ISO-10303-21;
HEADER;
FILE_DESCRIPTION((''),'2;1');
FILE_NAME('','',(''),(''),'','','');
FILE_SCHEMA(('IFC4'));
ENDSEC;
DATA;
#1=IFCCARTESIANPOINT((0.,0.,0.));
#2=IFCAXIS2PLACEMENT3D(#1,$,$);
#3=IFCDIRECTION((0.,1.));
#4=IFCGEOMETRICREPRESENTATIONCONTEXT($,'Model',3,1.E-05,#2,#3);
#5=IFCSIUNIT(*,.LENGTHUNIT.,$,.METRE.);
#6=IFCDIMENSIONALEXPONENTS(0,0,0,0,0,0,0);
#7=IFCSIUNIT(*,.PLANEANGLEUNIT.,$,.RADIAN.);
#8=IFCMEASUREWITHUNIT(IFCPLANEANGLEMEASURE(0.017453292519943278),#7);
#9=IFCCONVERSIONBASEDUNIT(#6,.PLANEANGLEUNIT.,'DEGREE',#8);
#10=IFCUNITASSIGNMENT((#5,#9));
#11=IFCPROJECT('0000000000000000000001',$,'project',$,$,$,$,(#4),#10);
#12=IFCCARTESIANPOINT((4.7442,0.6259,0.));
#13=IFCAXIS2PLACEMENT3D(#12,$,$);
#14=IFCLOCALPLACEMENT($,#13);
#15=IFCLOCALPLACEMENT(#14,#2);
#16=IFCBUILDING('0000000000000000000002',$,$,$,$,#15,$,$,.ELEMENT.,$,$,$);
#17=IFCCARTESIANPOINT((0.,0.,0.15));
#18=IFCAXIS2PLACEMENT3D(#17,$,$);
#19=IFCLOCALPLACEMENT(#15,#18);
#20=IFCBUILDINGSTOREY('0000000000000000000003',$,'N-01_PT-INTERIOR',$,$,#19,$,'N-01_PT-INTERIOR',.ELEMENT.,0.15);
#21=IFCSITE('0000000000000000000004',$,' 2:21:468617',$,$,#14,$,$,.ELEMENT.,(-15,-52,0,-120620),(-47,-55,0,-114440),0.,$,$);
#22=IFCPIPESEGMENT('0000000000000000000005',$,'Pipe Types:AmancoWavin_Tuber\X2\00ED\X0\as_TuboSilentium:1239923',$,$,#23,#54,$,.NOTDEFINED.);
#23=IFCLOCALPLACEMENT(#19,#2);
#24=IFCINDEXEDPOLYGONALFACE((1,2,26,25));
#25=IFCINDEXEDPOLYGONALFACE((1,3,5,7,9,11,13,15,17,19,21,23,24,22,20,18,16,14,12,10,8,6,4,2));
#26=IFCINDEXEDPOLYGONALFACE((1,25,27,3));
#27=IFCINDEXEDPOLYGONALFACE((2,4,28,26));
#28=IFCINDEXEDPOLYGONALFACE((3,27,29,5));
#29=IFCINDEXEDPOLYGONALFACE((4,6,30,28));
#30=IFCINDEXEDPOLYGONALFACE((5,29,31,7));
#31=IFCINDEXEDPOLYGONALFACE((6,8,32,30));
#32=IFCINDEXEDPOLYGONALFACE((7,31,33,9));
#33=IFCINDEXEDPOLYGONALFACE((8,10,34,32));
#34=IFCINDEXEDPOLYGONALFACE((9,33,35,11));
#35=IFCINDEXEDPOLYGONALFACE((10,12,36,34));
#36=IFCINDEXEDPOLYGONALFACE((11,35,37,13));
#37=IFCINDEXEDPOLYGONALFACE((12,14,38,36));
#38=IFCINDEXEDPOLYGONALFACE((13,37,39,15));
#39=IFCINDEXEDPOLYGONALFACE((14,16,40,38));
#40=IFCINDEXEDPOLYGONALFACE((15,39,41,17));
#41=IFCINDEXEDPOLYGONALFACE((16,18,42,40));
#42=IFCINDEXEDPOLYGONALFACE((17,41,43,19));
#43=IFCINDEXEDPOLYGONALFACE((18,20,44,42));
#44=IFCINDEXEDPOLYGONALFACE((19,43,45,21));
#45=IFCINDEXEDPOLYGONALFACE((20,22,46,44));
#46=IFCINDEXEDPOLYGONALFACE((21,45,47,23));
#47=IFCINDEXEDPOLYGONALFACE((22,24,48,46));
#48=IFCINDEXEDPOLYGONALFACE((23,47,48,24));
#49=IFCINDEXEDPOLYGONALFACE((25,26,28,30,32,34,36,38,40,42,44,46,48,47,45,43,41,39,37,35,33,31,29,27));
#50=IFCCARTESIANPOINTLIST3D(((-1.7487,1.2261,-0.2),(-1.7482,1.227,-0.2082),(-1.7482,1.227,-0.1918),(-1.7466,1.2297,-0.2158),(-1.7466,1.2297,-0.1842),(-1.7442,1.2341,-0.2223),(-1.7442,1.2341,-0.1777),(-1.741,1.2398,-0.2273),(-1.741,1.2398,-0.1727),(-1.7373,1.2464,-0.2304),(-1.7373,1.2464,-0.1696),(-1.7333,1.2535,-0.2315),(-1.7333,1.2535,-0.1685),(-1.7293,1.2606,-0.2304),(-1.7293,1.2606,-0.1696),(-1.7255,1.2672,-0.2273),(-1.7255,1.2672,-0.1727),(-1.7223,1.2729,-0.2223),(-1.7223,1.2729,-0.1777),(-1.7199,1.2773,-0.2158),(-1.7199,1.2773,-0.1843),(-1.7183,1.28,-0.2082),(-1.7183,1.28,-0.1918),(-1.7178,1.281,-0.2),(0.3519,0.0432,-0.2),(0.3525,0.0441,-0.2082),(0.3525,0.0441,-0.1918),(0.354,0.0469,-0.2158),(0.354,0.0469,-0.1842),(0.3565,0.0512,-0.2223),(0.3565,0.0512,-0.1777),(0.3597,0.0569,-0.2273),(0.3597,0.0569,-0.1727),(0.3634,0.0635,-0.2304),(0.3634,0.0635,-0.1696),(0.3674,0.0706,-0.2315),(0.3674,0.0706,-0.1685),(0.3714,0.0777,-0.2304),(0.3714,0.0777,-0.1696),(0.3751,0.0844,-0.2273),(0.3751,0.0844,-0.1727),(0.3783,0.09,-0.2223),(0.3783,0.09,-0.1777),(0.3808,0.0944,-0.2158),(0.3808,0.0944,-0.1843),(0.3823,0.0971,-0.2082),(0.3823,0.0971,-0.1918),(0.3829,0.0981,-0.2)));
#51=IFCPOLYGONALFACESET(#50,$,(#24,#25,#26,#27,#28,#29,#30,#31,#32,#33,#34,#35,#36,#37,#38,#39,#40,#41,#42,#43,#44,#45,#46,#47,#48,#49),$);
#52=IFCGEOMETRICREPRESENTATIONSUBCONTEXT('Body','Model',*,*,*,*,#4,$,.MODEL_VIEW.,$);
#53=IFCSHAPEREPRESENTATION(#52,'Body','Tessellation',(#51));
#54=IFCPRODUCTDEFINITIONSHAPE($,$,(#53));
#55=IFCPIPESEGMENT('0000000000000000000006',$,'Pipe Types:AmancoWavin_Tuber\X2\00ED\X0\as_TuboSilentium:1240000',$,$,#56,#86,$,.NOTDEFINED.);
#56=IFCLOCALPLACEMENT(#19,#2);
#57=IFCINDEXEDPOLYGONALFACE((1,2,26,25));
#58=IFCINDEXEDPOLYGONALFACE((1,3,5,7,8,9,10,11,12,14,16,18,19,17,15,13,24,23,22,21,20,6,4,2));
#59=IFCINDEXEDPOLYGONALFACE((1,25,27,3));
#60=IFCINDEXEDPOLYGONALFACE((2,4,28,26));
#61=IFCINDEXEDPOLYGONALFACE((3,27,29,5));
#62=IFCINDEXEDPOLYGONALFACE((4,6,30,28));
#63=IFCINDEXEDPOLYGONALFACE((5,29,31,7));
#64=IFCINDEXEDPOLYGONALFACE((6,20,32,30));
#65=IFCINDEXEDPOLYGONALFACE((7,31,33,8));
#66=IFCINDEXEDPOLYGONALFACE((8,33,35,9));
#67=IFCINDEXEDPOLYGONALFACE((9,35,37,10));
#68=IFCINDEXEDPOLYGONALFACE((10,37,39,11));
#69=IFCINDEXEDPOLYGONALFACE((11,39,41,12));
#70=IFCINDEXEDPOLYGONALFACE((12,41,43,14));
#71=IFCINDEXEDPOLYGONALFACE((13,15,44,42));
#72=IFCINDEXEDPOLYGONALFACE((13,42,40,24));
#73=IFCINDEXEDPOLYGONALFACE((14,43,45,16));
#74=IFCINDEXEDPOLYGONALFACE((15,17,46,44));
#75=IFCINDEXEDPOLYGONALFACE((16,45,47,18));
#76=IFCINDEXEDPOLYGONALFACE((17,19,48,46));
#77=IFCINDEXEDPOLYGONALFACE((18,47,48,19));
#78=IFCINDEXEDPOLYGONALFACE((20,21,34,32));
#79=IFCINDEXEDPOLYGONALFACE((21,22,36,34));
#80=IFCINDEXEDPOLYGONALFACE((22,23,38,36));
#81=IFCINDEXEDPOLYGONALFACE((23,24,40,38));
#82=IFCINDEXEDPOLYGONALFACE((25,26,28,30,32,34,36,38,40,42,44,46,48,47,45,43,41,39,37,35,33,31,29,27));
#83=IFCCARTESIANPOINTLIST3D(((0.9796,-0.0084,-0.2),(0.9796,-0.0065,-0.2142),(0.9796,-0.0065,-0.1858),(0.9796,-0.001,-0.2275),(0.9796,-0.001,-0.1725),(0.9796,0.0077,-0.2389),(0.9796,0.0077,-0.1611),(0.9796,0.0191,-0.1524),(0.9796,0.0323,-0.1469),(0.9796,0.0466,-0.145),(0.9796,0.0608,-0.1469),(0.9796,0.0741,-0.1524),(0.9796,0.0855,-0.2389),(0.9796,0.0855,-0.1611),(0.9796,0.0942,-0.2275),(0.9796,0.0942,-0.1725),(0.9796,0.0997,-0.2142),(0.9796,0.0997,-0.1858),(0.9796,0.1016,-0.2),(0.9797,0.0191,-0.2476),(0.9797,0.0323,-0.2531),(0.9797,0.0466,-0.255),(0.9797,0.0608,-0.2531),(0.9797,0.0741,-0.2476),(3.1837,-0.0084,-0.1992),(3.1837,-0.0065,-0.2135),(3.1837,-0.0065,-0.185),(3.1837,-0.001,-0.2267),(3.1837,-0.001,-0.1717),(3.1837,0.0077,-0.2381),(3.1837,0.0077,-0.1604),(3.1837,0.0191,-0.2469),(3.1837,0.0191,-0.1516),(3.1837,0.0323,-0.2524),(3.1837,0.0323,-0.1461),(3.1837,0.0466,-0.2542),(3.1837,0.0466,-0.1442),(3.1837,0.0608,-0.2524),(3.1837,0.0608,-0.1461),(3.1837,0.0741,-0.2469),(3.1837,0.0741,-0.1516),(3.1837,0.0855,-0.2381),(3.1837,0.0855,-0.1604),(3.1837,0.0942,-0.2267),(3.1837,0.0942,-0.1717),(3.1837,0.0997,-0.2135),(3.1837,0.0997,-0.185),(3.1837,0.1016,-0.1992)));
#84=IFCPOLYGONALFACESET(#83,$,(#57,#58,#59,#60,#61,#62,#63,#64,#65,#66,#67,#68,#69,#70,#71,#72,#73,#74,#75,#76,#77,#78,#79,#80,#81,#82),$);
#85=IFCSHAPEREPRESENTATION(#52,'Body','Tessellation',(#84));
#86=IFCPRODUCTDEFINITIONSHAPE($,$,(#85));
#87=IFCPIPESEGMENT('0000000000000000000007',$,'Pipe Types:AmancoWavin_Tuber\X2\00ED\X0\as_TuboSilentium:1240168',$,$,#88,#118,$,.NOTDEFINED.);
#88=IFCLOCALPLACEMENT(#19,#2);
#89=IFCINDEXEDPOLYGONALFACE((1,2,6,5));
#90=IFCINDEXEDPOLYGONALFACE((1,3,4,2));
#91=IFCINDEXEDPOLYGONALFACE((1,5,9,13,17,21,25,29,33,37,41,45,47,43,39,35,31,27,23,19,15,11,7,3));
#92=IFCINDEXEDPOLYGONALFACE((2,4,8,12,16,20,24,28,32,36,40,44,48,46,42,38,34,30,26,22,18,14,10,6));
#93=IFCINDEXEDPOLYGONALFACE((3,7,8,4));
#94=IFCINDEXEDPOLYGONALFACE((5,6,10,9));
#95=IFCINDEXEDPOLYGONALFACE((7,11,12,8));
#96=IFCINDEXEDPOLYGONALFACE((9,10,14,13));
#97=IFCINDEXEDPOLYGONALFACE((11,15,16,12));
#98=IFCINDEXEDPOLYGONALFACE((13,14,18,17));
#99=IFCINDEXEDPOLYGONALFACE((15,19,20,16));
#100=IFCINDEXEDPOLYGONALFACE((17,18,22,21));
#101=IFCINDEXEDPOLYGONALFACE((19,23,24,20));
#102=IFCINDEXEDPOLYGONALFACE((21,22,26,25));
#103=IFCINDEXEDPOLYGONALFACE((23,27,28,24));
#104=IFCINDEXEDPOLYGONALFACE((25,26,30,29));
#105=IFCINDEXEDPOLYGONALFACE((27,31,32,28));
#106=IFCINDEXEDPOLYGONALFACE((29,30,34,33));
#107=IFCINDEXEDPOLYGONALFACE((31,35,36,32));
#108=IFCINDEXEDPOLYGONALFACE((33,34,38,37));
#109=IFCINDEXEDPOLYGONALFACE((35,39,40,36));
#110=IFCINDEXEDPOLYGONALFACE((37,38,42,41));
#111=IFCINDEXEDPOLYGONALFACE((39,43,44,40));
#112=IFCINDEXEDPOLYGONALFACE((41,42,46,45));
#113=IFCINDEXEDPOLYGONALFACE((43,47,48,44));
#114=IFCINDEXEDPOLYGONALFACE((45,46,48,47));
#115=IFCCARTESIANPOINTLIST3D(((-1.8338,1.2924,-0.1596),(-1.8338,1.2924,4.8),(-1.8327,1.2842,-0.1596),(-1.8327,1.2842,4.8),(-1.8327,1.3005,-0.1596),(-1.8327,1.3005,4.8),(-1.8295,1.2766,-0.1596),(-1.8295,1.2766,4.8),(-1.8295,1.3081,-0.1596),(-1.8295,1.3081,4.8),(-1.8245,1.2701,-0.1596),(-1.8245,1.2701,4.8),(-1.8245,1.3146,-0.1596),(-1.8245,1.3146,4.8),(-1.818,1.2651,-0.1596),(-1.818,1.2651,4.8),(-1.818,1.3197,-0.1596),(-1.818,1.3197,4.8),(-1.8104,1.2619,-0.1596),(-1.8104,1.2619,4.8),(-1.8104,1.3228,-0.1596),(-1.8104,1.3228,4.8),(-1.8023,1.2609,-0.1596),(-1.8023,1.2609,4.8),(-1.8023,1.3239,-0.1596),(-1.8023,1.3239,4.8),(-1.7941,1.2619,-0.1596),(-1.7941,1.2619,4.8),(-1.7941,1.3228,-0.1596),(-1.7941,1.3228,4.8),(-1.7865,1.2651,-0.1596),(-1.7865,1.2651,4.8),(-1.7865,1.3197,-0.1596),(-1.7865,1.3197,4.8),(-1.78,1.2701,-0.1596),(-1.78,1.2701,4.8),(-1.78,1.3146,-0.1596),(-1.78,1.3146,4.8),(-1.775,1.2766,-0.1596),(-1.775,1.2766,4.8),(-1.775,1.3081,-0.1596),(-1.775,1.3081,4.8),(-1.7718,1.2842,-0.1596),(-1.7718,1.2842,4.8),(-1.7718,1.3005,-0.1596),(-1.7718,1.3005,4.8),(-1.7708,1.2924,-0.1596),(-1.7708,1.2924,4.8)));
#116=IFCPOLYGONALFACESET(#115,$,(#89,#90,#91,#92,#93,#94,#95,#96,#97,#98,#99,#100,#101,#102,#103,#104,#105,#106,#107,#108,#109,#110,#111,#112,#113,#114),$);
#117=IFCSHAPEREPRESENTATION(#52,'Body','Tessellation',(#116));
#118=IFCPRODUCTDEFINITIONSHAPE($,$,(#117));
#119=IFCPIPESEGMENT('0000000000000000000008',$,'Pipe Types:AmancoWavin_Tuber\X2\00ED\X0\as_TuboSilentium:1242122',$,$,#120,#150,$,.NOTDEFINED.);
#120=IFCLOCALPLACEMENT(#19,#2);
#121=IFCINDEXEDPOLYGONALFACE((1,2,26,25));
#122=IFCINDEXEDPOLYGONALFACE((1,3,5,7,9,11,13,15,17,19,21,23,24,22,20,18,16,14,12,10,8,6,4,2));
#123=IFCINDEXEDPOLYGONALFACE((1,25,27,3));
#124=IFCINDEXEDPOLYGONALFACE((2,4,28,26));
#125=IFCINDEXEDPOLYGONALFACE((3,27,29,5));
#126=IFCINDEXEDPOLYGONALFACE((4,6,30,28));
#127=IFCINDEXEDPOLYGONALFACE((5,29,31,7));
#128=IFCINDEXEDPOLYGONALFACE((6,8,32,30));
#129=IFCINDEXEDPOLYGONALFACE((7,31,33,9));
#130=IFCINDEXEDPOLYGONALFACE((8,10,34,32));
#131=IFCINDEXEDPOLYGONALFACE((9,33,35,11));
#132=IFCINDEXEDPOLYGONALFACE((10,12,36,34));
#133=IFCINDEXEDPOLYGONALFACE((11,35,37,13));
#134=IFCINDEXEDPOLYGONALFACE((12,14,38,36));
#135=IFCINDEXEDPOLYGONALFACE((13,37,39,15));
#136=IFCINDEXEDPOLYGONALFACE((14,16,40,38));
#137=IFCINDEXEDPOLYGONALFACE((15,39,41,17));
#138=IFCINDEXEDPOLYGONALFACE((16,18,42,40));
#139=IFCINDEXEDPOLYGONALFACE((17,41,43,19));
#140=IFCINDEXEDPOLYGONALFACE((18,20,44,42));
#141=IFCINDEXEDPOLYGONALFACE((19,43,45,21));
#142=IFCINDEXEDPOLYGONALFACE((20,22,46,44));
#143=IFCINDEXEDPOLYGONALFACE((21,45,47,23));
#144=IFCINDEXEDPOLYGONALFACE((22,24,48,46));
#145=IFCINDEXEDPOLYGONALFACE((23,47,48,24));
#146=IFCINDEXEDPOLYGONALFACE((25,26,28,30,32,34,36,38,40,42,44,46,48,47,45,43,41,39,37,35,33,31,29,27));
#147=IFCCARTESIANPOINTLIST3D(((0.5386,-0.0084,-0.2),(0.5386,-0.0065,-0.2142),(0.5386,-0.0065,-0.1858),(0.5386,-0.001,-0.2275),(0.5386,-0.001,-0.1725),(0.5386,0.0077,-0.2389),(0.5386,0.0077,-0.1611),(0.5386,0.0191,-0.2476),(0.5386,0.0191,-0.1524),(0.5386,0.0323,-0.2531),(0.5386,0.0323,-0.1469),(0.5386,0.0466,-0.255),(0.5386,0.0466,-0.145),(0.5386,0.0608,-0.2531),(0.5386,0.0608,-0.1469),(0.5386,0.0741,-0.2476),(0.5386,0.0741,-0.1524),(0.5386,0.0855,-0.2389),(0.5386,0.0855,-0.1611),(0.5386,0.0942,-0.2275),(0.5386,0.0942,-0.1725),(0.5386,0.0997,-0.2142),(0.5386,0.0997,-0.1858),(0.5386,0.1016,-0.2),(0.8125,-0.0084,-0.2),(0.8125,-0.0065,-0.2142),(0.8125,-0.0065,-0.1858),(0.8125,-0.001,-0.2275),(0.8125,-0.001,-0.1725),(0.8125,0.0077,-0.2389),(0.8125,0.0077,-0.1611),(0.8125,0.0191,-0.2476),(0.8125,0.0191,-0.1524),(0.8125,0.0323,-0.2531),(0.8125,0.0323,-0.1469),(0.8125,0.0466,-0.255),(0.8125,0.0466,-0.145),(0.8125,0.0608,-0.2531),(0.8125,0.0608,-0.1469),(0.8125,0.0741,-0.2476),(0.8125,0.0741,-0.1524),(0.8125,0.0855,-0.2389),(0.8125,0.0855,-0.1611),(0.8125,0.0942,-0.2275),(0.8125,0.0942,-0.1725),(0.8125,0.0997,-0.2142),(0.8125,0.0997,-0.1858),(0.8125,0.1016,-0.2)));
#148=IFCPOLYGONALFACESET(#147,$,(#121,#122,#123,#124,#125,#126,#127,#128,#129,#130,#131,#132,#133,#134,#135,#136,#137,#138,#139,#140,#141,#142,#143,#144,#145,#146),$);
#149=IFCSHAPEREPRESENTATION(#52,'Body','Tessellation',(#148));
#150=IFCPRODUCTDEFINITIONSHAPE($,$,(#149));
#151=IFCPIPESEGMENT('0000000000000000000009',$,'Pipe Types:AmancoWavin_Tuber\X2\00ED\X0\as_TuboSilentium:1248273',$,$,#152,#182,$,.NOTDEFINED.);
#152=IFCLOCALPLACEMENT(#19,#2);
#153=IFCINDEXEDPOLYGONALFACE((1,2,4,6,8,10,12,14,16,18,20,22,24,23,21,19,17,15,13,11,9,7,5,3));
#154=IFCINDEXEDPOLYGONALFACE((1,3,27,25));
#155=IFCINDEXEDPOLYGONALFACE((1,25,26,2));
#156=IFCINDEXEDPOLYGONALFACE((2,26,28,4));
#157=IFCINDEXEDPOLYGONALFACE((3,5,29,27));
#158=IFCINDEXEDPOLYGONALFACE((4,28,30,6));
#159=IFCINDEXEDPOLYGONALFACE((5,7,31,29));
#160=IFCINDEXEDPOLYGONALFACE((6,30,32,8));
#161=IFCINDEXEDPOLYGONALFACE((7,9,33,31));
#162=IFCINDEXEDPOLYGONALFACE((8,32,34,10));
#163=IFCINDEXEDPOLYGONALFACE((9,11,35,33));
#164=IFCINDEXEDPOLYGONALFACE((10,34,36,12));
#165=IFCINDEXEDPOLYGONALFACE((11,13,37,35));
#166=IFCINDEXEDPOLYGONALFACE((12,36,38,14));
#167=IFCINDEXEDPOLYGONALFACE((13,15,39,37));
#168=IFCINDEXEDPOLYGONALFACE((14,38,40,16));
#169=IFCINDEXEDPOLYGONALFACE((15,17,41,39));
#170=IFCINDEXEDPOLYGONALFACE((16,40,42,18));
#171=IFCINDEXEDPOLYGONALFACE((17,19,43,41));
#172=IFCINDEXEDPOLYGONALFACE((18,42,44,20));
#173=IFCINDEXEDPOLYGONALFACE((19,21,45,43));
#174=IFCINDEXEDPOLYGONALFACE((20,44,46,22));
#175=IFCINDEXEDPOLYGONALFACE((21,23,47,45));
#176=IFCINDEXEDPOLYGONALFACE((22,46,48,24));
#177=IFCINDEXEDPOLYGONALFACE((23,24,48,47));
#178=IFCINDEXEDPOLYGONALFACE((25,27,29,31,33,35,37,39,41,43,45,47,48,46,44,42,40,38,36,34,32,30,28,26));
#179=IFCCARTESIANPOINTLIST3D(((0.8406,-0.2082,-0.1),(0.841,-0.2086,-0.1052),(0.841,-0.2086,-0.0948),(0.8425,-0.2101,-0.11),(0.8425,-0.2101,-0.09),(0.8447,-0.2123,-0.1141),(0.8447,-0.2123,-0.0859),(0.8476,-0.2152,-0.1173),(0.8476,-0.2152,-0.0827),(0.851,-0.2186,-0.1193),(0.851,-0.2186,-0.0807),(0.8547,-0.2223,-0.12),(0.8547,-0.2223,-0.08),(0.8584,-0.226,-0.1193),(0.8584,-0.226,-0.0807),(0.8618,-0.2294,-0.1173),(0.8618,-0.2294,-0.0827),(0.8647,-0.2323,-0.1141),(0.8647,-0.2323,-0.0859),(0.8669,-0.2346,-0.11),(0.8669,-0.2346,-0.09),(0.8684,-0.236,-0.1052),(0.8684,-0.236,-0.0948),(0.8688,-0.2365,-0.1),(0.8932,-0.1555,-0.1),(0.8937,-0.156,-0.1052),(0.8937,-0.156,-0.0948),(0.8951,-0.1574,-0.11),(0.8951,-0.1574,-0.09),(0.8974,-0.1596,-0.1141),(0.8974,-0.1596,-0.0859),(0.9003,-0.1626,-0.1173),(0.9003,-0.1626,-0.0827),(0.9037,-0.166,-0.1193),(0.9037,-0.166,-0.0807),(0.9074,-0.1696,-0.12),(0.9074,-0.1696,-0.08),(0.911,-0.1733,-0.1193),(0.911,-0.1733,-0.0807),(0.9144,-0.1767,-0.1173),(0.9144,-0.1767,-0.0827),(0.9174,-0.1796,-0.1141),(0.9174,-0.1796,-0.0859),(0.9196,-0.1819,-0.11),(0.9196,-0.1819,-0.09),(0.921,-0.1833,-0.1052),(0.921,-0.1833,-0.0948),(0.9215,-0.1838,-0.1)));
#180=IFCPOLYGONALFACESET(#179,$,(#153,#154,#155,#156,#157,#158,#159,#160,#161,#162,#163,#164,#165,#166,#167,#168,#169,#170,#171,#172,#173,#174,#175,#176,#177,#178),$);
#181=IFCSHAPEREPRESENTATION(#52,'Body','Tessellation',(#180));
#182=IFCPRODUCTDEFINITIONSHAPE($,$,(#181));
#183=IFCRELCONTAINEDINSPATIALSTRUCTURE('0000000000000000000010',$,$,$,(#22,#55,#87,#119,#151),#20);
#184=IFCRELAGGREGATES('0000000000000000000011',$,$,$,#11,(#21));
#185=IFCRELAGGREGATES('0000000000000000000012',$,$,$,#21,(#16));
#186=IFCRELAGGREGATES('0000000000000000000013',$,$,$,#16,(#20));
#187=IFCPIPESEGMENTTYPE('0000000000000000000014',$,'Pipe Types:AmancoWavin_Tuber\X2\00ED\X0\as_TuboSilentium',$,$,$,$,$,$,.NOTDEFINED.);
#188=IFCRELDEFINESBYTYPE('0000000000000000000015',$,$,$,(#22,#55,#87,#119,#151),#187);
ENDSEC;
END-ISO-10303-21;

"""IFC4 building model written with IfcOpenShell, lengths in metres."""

from ifc_helpers import new_model, entity, si_unit, converted_unit, direction, frame, origin, place, context, subcontext, project, spatial, arc, indexed_curve, outline, extrude, type_object, element, save


model = new_model("IFC4")

# Units and contexts
model_context = context("Model", 3, precision=1e-05, world=origin(), true_north=direction((0.0, 1.0)))
body_context = subcontext(model_context, "Body", "Model", "MODEL_VIEW")
ifc_project = project(units=[si_unit("LENGTHUNIT", "METRE"), converted_unit("PLANEANGLEUNIT", "DEGREE", entity("IfcPlaneAngleMeasure", 0.017453292519943278), si_unit("PLANEANGLEUNIT", "RADIAN"), dimensions=[0, 0, 0, 0, 0, 0, 0])], contexts=[model_context])

# Site, building, storey
site_placement = place(None, frame((4.7442, 0.6259, 0.0)))
site = spatial("IfcSite", under=ifc_project, at=site_placement, Name=" 2:21:468617", CompositionType="ELEMENT", RefLatitude=(-15, -52, 0, -120620), RefLongitude=(-47, -55, 0, -114440), RefElevation=0.0)
building_placement = place(site_placement, origin())
building = spatial("IfcBuilding", under=site, at=building_placement, CompositionType="ELEMENT")
storey_placement = place(building_placement, frame((0.0, 0.0, 0.15)))
storey = spatial("IfcBuildingStorey", under=building, at=storey_placement, Name="N-01_PT-INTERIOR", LongName="N-01_PT-INTERIOR", CompositionType="ELEMENT", Elevation=0.15)

# Pipe segments
pipe_segment_type_1 = type_object("IfcPipeSegmentType", Name="Pipe Types:AmancoWavin_Tuberías_TuboSilentium", PredefinedType="NOTDEFINED")
pipe_segment_1_placement = place(storey_placement, origin())
element("IfcPipeSegment", 1, at=pipe_segment_1_placement, inside=storey, type_object=pipe_segment_type_1, Name="Pipe Types:AmancoWavin_Tuberías_TuboSilentium:1239923", PredefinedType="NOTDEFINED", context=body_context, shape_type="SweptSolid", body=[
    extrude(outline(indexed_curve([(0.0315, 0.0), (0.0223, 0.0223), (0.0, 0.0315), (-0.0223, 0.0223), (-0.0315, 0.0), (-0.0223, -0.0223), (0.0, -0.0315), (0.0223, -0.0223)], segments=[arc(1, 2, 3), arc(3, 4, 5), arc(5, 6, 7), arc(7, 8, 1)], self_intersect=False)), frame((-1.7333, 1.2535, -0.2), z_axis=(0.871352, -0.490659, 0.0), x_axis=(-0.490659, -0.871352, 0.0)), (0.0, 0.0, 1.0), 2.4108),
])
pipe_segment_2_placement = place(storey_placement, origin())
element("IfcPipeSegment", 2, at=pipe_segment_2_placement, inside=storey, type_object=pipe_segment_type_1, Name="Pipe Types:AmancoWavin_Tuberías_TuboSilentium:1240000", PredefinedType="NOTDEFINED", context=body_context, shape_type="SweptSolid", body=[
    extrude(outline(indexed_curve([(0.055, 0.0), (0.0389, 0.0389), (0.0, 0.055), (-0.0389, 0.0389), (-0.055, 0.0), (-0.0389, -0.0389), (0.0, -0.055), (0.0389, -0.0389)], segments=[arc(1, 2, 3), arc(3, 4, 5), arc(5, 6, 7), arc(7, 8, 1)], self_intersect=False)), frame((0.9796, 0.0466, -0.2), z_axis=(1.0, 0.0, 0.000343), x_axis=(0.0, 1.0, 0.0)), (0.0, 0.0, 1.0), 2.204),
])
pipe_segment_3_placement = place(storey_placement, origin())
element("IfcPipeSegment", 3, at=pipe_segment_3_placement, inside=storey, type_object=pipe_segment_type_1, Name="Pipe Types:AmancoWavin_Tuberías_TuboSilentium:1240168", PredefinedType="NOTDEFINED", context=body_context, shape_type="SweptSolid", body=[
    extrude(outline(indexed_curve([(0.0315, 0.0), (0.0223, 0.0223), (0.0, 0.0315), (-0.0223, 0.0223), (-0.0315, 0.0), (-0.0223, -0.0223), (0.0, -0.0315), (0.0223, -0.0223)], segments=[arc(1, 2, 3), arc(3, 4, 5), arc(5, 6, 7), arc(7, 8, 1)], self_intersect=False)), frame((-1.8023, 1.2924, -0.1596), z_axis=(0.0, 0.0, 1.0), x_axis=(-1.0, 0.0, 0.0)), (0.0, 0.0, 1.0), 4.9597),
])
pipe_segment_4_placement = place(storey_placement, origin())
element("IfcPipeSegment", 4, at=pipe_segment_4_placement, inside=storey, type_object=pipe_segment_type_1, Name="Pipe Types:AmancoWavin_Tuberías_TuboSilentium:1242122", PredefinedType="NOTDEFINED", context=body_context, shape_type="SweptSolid", body=[
    extrude(outline(indexed_curve([(0.055, 0.0), (0.0389, 0.0389), (0.0, 0.055), (-0.0389, 0.0389), (-0.055, 0.0), (-0.0389, -0.0389), (0.0, -0.055), (0.0389, -0.0389)], segments=[arc(1, 2, 3), arc(3, 4, 5), arc(5, 6, 7), arc(7, 8, 1)], self_intersect=False)), frame((0.5386, 0.0466, -0.2), z_axis=(1.0, 0.0, 0.0), x_axis=(0.0, -1.0, 0.0)), (0.0, 0.0, 1.0), 0.274),
])
pipe_segment_5_placement = place(storey_placement, origin())
element("IfcPipeSegment", 5, at=pipe_segment_5_placement, inside=storey, type_object=pipe_segment_type_1, Name="Pipe Types:AmancoWavin_Tuberías_TuboSilentium:1248273", PredefinedType="NOTDEFINED", context=body_context, shape_type="SweptSolid", body=[
    extrude(outline(indexed_curve([(0.02, 0.0), (0.0141, 0.0141), (0.0, 0.02), (-0.0141, 0.0141), (-0.02, 0.0), (-0.0141, -0.0141), (0.0, -0.02), (0.0141, -0.0141)], segments=[arc(1, 2, 3), arc(3, 4, 5), arc(5, 6, 7), arc(7, 8, 1)], self_intersect=False)), frame((0.8547, -0.2223, -0.1), z_axis=(0.707107, 0.707107, 0.0), x_axis=(0.707107, -0.707107, 0.0)), (0.0, 0.0, 1.0), 0.0745),
])

save(model, "model.ifc")
